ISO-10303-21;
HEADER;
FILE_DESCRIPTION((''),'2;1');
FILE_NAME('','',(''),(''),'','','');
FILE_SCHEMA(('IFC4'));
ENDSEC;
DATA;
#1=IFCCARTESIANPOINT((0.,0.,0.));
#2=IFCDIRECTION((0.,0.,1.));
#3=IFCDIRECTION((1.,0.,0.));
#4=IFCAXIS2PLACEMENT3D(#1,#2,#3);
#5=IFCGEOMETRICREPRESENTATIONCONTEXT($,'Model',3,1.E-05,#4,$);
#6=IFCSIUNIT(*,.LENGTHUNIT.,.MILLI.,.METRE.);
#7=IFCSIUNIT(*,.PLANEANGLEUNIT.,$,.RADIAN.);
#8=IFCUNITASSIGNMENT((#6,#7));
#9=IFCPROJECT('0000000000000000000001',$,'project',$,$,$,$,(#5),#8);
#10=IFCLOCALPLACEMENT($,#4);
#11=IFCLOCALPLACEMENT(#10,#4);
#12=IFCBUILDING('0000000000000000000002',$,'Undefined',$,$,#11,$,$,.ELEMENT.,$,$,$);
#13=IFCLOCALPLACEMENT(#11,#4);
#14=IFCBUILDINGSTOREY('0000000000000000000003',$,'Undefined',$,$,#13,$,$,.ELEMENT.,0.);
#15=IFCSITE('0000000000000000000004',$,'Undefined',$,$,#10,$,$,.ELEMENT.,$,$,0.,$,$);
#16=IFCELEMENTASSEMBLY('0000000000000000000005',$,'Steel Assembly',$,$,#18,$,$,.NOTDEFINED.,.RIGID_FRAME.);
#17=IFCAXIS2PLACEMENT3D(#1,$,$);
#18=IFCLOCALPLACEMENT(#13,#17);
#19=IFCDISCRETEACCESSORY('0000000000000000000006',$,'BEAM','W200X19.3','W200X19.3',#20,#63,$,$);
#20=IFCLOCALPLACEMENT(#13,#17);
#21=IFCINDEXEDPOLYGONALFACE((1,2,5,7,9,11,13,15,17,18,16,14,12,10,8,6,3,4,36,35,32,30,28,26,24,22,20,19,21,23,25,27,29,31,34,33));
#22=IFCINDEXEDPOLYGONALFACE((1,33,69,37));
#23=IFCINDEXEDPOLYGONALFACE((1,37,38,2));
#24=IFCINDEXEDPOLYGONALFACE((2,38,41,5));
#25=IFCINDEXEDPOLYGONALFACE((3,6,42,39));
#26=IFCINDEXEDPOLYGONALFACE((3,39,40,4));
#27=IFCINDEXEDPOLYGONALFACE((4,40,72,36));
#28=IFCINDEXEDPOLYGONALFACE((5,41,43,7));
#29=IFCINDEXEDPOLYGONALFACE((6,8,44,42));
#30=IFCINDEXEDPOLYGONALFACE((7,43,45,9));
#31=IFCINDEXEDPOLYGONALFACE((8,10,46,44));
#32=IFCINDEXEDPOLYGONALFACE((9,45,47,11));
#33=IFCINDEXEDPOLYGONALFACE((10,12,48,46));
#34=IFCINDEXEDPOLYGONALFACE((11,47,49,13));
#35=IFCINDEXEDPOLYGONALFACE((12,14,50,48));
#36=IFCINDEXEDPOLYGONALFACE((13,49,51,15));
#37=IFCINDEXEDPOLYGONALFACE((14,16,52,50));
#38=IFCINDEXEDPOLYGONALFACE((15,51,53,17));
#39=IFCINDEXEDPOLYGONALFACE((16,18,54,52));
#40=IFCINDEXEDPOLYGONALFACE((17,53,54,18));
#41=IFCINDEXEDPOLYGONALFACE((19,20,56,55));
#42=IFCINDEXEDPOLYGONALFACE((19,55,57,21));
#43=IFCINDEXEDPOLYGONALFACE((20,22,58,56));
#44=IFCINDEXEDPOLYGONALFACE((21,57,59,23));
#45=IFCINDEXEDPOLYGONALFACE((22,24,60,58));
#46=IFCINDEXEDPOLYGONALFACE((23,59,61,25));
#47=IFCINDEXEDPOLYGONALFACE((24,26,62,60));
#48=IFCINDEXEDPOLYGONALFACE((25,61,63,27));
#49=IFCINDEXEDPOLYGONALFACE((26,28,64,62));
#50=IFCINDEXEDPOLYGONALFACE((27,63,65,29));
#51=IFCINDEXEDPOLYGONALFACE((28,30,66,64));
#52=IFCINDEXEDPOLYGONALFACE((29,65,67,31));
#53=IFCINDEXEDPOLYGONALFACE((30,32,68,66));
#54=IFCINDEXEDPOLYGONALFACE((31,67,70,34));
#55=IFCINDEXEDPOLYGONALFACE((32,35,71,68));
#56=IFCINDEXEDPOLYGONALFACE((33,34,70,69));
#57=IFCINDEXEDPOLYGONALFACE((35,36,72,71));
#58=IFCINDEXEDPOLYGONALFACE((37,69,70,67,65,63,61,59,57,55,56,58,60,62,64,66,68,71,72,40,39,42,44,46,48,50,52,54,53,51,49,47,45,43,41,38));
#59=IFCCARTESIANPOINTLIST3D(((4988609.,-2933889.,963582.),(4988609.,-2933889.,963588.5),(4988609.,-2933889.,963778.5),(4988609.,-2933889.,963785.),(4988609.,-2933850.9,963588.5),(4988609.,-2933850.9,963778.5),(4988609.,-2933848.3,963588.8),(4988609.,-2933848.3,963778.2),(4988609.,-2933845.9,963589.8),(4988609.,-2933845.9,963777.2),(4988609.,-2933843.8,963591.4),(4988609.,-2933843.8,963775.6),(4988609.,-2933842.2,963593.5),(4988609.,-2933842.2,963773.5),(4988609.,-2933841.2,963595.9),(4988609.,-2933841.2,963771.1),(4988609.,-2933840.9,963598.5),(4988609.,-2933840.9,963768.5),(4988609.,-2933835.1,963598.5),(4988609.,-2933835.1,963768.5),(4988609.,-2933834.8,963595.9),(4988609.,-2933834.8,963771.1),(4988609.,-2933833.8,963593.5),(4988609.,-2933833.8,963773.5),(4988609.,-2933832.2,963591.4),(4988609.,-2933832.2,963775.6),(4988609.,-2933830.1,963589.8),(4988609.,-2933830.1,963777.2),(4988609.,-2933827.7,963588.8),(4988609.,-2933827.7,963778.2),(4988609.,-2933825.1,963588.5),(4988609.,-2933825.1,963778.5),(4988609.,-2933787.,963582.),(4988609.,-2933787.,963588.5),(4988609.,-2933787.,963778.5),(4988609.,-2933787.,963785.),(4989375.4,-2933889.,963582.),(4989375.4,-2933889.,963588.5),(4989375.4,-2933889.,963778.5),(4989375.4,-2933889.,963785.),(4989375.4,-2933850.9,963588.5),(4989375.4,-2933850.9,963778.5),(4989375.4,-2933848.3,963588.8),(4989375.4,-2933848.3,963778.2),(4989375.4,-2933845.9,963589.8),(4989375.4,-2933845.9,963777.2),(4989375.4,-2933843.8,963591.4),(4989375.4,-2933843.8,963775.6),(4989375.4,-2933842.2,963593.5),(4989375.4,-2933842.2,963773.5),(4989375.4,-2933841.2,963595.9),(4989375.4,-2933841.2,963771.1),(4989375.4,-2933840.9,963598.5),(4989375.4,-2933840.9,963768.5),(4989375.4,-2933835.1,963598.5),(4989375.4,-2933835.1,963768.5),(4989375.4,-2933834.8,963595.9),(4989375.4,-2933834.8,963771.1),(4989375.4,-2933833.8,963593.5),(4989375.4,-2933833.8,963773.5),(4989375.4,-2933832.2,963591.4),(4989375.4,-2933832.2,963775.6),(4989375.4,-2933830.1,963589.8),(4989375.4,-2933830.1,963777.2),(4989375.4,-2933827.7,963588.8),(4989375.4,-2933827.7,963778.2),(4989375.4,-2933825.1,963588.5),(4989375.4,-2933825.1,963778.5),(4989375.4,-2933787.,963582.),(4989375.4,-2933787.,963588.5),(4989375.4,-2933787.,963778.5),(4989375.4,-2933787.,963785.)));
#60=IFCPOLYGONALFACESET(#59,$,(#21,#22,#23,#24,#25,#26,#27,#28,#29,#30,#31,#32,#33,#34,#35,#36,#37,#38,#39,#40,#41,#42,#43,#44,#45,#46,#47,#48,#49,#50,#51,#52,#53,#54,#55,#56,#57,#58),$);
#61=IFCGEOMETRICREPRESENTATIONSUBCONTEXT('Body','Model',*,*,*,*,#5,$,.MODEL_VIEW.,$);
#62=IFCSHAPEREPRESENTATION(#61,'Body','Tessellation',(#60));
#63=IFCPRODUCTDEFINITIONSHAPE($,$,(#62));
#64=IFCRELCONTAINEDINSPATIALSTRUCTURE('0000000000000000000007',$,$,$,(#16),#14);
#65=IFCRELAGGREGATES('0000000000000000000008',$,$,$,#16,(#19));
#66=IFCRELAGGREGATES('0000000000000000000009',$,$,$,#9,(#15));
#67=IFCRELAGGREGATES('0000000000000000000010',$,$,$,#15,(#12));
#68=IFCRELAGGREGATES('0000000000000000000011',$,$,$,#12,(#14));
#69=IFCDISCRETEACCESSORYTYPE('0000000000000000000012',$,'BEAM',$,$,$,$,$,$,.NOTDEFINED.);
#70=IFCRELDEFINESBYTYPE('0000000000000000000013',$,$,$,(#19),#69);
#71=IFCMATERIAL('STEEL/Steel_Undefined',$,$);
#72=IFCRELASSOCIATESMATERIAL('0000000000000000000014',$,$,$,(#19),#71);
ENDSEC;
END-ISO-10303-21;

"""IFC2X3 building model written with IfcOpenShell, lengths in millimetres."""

from ifc_helpers import new_model, si_unit, frame, origin_with_axes, origin_2d_with_axis, place, context, subcontext, project, spatial, i_section, extrude, clip, halfspace, material, type_object, element, aggregate, save


model = new_model("IFC2X3")

# Units and contexts
model_context = context("Model", 3, precision=1e-05, world=origin_with_axes())
body_context = subcontext(model_context, "Body", "Model", "MODEL_VIEW")
ifc_project = project(units=[si_unit("LENGTHUNIT", "METRE", prefix="MILLI"), si_unit("PLANEANGLEUNIT", "RADIAN")], contexts=[model_context])

# Site, building, storey
site_placement = place(None, origin_with_axes())
site = spatial("IfcSite", under=ifc_project, at=site_placement, Name="Undefined", CompositionType="ELEMENT", RefElevation=0.0)
building_placement = place(site_placement, origin_with_axes())
building = spatial("IfcBuilding", under=site, at=building_placement, Name="Undefined", CompositionType="ELEMENT")
storey_placement = place(building_placement, origin_with_axes())
storey = spatial("IfcBuildingStorey", under=building, at=storey_placement, Name="Undefined", CompositionType="ELEMENT", Elevation=0.0)

# Shared definitions
ifc_material_1 = material(Name="STEEL/Steel_Undefined")

# Element assembly
assembly_1_placement = place(storey_placement, origin_with_axes())
assembly_1 = element("IfcElementAssembly", 1, at=assembly_1_placement, inside=storey, Name="Steel Assembly", AssemblyPlace="NOTDEFINED", PredefinedType="RIGID_FRAME")

# Discrete accessory
discrete_accessory_type_1 = type_object("IfcDiscreteAccessoryType", Name="BEAM")
discrete_accessory_1_placement = place(assembly_1_placement, frame((4989375.5, -2933838.0, 963683.5), z_axis=(0.0, 0.0, -1.0), x_axis=(-1.0, 0.0, 0.0)))
discrete_accessory_1 = element("IfcDiscreteAccessory", 2, at=discrete_accessory_1_placement, type_object=discrete_accessory_type_1, material=ifc_material_1, Name="BEAM", Description="W200X19.3", ObjectType="W200X19.3", context=body_context, shape_type="Clipping", body=[
    clip(extrude(i_section(OverallWidth=102.0, OverallDepth=203.0, WebThickness=5.8, FlangeThickness=6.5, FilletRadius=10.0, at=origin_2d_with_axis()), frame((766.5, 0.0, 0.0), z_axis=(-1.0, 0.0, 0.0), x_axis=(0.0, -1.0, 0.0)), (0.0, 0.0, 1.0), 766.4), halfspace(frame((0.1, 0.0, -1101.5), z_axis=(-1.0, 0.0, 0.0), x_axis=(0.0, 1.0, 0.0)), False)),
])
aggregate(assembly_1, [discrete_accessory_1])

save(model, "model.ifc")
